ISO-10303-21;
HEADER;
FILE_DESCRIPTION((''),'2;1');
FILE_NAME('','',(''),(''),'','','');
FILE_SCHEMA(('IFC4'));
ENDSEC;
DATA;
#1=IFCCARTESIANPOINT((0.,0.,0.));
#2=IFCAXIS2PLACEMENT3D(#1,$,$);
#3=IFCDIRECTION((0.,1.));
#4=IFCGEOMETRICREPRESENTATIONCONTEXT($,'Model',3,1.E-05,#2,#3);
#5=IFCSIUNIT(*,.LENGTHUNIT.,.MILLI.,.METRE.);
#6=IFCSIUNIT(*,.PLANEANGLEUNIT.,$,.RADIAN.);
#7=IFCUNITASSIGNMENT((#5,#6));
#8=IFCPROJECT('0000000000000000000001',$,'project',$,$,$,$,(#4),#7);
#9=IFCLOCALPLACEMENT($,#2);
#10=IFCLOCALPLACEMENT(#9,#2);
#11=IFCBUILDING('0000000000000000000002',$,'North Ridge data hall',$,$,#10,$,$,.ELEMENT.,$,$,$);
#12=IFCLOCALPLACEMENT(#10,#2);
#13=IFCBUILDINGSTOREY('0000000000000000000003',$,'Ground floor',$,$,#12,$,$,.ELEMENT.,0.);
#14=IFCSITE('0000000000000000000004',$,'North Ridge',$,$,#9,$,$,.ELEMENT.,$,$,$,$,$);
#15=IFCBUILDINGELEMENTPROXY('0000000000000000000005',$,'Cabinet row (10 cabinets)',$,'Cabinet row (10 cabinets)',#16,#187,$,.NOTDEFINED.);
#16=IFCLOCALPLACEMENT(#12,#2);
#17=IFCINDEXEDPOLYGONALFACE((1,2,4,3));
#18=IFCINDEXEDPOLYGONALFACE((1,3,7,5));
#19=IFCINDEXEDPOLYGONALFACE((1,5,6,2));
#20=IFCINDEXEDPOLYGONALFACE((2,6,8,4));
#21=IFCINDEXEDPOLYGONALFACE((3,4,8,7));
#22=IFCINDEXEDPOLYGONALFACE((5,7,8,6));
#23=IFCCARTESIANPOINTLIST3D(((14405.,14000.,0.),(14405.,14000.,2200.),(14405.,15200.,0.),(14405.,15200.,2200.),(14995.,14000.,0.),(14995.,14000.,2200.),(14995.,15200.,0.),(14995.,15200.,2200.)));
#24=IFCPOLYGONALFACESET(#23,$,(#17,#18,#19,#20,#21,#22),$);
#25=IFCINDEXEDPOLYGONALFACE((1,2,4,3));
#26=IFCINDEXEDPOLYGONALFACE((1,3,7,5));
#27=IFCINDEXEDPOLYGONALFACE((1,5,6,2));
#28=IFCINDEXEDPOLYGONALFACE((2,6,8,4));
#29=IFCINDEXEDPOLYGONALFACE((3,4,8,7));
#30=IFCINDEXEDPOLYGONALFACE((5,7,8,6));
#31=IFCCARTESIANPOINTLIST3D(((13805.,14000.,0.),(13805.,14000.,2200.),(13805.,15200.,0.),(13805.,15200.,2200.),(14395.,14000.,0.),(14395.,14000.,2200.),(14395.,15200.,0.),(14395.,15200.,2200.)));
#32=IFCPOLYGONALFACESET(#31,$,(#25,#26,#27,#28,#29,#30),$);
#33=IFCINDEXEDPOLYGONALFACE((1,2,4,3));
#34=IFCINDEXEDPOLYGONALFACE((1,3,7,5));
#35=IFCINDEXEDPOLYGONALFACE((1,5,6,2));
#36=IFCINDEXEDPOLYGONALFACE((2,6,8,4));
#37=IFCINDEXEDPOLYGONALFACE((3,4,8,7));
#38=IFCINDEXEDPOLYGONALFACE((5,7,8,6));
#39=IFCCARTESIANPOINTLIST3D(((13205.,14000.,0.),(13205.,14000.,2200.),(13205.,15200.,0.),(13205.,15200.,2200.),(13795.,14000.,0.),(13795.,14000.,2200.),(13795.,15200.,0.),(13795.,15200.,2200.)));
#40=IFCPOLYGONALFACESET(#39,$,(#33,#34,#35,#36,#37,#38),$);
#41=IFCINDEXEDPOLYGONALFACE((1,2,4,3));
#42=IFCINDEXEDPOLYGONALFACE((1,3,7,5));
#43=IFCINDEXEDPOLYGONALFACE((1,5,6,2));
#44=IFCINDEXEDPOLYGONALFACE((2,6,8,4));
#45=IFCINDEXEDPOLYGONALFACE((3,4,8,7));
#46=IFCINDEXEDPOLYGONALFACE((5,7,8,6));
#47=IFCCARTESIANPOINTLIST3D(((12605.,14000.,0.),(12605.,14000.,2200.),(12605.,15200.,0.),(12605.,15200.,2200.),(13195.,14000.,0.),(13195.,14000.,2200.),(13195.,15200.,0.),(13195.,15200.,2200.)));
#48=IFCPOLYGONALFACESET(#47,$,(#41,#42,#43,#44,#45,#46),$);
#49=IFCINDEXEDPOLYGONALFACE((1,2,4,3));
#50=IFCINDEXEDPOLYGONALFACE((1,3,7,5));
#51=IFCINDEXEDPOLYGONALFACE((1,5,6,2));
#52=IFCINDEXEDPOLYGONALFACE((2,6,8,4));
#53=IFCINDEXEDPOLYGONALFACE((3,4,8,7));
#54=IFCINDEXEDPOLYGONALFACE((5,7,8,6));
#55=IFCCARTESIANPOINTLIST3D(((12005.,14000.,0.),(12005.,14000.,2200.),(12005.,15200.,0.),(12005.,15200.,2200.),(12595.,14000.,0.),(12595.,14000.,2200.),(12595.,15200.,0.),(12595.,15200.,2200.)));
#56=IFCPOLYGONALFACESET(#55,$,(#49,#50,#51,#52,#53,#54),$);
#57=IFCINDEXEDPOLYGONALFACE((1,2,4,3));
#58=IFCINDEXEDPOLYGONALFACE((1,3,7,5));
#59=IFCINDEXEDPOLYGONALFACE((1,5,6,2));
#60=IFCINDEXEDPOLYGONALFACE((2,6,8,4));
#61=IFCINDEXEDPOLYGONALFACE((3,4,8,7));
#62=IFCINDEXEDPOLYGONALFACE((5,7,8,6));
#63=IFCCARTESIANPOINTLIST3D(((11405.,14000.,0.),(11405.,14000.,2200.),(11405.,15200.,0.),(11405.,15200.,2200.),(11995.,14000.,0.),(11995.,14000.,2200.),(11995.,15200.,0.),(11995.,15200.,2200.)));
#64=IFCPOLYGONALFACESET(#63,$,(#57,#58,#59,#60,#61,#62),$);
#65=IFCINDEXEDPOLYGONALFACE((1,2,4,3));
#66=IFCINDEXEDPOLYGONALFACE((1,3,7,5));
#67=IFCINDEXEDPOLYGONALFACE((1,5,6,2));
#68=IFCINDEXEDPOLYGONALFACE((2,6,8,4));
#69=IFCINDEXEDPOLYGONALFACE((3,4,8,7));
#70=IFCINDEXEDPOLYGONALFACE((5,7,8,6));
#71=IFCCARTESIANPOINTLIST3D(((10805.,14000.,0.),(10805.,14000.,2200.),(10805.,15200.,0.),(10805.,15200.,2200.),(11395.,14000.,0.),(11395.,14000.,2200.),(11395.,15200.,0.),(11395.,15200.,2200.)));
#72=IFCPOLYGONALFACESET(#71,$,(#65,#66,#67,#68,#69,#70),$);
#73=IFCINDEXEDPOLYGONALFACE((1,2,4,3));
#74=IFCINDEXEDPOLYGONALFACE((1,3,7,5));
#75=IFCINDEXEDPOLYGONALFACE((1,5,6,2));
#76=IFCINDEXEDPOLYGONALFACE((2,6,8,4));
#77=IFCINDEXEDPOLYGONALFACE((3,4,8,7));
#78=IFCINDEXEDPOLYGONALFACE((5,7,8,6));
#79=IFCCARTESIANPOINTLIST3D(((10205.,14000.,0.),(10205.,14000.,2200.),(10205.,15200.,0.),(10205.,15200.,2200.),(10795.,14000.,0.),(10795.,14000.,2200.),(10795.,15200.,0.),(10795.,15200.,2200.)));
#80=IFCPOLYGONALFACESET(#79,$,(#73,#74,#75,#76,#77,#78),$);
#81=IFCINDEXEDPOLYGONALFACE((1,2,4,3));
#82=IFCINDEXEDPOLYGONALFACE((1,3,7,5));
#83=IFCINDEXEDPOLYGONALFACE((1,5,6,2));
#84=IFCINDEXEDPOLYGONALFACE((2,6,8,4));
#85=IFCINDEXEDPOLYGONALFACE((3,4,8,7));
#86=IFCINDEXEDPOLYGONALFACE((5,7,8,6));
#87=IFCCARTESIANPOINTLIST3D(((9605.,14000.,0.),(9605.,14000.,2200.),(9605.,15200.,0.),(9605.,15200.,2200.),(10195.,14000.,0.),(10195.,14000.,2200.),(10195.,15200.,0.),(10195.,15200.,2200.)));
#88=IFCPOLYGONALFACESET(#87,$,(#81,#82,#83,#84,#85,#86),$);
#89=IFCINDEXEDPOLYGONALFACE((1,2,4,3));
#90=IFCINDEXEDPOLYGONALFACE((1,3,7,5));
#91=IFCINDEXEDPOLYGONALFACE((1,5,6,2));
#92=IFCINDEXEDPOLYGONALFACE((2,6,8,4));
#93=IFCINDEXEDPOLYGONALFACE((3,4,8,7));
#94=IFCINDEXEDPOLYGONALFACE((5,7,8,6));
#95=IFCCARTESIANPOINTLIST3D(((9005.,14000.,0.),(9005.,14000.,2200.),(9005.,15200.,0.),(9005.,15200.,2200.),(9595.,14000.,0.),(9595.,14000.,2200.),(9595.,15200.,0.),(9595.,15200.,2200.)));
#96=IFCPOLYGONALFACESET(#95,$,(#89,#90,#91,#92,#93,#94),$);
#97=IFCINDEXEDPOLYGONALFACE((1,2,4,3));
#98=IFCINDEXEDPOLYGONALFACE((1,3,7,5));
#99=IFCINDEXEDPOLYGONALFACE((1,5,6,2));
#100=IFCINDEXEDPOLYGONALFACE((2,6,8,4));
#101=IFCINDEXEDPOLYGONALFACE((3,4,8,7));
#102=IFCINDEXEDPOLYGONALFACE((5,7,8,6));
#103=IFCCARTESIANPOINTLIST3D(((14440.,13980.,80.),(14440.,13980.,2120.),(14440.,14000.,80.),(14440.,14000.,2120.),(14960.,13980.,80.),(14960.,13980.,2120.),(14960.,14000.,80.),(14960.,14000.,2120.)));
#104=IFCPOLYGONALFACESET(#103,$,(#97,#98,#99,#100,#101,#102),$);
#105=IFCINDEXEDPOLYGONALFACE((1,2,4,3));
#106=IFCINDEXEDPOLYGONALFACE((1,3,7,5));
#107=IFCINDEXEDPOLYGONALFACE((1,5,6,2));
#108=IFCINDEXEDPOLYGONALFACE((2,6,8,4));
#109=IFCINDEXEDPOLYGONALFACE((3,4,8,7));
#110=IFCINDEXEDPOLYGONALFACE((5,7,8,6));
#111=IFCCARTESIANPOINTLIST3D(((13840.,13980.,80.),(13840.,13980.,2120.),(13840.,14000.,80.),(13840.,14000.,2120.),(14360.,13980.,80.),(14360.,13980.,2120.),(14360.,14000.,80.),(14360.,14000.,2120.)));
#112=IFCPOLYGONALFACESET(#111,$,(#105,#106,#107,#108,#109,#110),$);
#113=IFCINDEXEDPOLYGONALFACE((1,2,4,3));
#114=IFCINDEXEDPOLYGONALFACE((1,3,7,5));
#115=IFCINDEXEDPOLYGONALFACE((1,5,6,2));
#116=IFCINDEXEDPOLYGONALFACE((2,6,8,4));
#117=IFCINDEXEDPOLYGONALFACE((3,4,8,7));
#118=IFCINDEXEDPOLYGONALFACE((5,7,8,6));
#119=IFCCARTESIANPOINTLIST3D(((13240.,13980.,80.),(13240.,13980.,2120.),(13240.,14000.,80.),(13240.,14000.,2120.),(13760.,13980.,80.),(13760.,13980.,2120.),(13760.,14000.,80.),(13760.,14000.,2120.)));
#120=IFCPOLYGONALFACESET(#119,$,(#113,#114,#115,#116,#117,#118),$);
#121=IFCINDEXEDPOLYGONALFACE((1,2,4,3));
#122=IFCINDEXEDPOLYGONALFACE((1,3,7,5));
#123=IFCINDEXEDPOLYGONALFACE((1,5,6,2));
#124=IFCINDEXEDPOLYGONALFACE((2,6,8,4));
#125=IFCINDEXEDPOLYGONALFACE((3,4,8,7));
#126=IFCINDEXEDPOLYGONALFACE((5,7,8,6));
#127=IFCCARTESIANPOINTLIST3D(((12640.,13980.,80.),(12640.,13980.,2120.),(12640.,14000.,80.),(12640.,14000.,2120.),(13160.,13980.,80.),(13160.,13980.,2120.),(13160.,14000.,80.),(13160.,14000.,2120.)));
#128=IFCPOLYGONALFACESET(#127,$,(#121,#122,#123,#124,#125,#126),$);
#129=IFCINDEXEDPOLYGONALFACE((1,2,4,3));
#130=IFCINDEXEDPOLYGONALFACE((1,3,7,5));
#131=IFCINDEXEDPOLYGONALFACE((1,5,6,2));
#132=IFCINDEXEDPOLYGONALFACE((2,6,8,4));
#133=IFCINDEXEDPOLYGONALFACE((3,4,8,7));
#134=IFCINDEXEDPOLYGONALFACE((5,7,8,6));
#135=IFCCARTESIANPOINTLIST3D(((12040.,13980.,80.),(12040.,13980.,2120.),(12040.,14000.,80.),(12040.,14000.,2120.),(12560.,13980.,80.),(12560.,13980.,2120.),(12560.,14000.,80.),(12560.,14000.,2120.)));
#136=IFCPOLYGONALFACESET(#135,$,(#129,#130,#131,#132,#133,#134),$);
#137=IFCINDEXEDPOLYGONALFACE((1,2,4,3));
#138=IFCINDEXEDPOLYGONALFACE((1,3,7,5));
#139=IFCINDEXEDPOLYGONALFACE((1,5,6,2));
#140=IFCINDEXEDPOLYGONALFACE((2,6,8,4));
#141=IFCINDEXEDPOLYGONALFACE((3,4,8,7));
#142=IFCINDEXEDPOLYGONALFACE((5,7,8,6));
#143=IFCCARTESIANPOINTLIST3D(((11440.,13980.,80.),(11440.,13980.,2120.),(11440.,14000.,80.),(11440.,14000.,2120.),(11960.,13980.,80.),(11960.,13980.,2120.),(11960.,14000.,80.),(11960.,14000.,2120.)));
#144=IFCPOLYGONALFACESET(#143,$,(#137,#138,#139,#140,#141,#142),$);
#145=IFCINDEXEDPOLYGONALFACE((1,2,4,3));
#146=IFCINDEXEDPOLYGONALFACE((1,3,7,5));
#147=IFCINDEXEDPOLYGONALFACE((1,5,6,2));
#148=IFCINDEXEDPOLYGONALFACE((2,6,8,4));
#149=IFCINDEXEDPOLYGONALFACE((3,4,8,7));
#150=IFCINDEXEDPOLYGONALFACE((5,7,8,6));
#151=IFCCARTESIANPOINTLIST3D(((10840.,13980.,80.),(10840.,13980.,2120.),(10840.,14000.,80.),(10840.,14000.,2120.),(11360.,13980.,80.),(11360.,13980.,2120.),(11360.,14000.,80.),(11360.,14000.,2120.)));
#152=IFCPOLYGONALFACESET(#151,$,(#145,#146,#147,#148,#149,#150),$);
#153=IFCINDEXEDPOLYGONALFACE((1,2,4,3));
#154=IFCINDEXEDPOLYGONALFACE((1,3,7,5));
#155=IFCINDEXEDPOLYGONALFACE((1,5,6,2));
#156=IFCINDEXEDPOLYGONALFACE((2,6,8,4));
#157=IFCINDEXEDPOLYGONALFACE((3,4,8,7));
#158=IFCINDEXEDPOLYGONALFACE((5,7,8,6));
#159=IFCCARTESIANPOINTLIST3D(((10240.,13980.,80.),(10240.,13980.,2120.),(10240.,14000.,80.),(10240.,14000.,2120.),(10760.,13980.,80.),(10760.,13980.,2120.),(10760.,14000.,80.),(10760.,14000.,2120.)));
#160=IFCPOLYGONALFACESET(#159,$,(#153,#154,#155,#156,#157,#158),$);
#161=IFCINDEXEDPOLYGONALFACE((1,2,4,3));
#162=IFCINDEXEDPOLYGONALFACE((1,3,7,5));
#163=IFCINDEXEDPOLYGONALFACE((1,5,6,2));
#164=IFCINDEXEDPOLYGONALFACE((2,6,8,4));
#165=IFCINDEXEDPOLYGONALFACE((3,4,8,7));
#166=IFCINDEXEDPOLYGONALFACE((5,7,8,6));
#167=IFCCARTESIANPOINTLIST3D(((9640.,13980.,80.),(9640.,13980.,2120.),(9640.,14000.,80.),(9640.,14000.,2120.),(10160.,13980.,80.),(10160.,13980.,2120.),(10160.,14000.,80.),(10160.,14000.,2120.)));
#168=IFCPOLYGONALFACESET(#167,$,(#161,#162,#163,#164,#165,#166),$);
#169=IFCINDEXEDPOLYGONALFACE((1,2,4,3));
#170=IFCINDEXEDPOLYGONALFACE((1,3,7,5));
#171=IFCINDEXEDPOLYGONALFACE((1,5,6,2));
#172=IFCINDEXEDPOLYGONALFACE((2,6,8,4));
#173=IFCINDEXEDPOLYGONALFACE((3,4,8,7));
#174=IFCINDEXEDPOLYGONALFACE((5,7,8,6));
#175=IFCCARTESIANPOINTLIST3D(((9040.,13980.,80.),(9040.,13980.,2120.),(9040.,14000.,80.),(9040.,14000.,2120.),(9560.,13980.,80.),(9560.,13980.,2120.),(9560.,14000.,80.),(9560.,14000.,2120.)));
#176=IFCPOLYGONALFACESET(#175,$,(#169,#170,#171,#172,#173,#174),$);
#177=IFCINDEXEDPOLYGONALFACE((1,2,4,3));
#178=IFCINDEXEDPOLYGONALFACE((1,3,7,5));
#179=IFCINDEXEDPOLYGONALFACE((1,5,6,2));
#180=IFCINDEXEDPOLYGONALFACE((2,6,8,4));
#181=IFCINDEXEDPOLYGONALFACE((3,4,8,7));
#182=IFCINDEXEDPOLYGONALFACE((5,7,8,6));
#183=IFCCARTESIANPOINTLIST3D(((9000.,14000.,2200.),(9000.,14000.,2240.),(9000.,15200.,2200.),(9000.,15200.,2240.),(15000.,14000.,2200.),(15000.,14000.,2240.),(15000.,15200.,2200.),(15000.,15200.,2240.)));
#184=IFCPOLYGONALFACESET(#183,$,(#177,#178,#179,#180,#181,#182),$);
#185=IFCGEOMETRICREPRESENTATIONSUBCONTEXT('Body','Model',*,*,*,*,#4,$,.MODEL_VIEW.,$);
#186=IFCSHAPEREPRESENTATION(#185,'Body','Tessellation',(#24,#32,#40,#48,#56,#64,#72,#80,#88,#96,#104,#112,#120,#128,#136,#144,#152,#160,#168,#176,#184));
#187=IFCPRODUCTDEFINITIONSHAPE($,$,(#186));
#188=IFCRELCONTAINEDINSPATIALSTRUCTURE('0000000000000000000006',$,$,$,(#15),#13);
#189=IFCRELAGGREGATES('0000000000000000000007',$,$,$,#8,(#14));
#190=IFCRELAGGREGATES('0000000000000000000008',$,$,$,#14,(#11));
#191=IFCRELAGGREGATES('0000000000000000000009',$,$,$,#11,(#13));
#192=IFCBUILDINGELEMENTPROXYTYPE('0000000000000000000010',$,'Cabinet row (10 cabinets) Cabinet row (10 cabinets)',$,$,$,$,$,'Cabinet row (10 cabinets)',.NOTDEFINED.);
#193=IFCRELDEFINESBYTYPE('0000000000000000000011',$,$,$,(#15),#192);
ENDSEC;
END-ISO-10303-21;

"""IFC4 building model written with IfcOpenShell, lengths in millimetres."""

from ifc_helpers import new_model, si_unit, direction, frame, origin, place, context, subcontext, project, spatial, polyline, outline, extrude, source, transform, mapped, type_object, type_shapes, element, save


model = new_model("IFC4")

# Units and contexts
model_context = context("Model", 3, precision=1e-05, world=origin(), true_north=direction((0.0, 1.0)))
body_context = subcontext(model_context, "Body", "Model", "MODEL_VIEW")
ifc_project = project(units=[si_unit("LENGTHUNIT", "METRE", prefix="MILLI"), si_unit("PLANEANGLEUNIT", "RADIAN")], contexts=[model_context])

# Site, building, storey
site_placement = place(None, origin())
site = spatial("IfcSite", under=ifc_project, at=site_placement, Name="North Ridge", CompositionType="ELEMENT")
building_placement = place(site_placement, origin())
building = spatial("IfcBuilding", under=site, at=building_placement, Name="North Ridge data hall", CompositionType="ELEMENT")
storey_placement = place(building_placement, origin())
storey = spatial("IfcBuildingStorey", under=building, at=storey_placement, Name="Ground floor", CompositionType="ELEMENT", Elevation=0.0)

# Building element proxy
building_element_proxy_type_1 = type_object("IfcBuildingElementProxyType", Name="Cabinet row (10 cabinets) Cabinet row (10 cabinets)", ElementType="Cabinet row (10 cabinets)", PredefinedType="NOTDEFINED")
shared_shape_1 = source(origin(), body_context, "Body", "SweptSolid", [
    extrude(outline(polyline([(5.0, 0.0), (595.0, 0.0), (595.0, 1200.0), (5.0, 1200.0), (5.0, 0.0)])), origin(), (0.0, 0.0, 1.0), 2200.0),
    extrude(outline(polyline([(605.0, 0.0), (1195.0, 0.0), (1195.0, 1200.0), (605.0, 1200.0), (605.0, 0.0)])), origin(), (0.0, 0.0, 1.0), 2200.0),
    extrude(outline(polyline([(1205.0, 0.0), (1795.0, 0.0), (1795.0, 1200.0), (1205.0, 1200.0), (1205.0, 0.0)])), origin(), (0.0, 0.0, 1.0), 2200.0),
    extrude(outline(polyline([(1805.0, 0.0), (2395.0, 0.0), (2395.0, 1200.0), (1805.0, 1200.0), (1805.0, 0.0)])), origin(), (0.0, 0.0, 1.0), 2200.0),
    extrude(outline(polyline([(2405.0, 0.0), (2995.0, 0.0), (2995.0, 1200.0), (2405.0, 1200.0), (2405.0, 0.0)])), origin(), (0.0, 0.0, 1.0), 2200.0),
    extrude(outline(polyline([(3005.0, 0.0), (3595.0, 0.0), (3595.0, 1200.0), (3005.0, 1200.0), (3005.0, 0.0)])), origin(), (0.0, 0.0, 1.0), 2200.0),
    extrude(outline(polyline([(3605.0, 0.0), (4195.0, 0.0), (4195.0, 1200.0), (3605.0, 1200.0), (3605.0, 0.0)])), origin(), (0.0, 0.0, 1.0), 2200.0),
    extrude(outline(polyline([(4205.0, 0.0), (4795.0, 0.0), (4795.0, 1200.0), (4205.0, 1200.0), (4205.0, 0.0)])), origin(), (0.0, 0.0, 1.0), 2200.0),
    extrude(outline(polyline([(4805.0, 0.0), (5395.0, 0.0), (5395.0, 1200.0), (4805.0, 1200.0), (4805.0, 0.0)])), origin(), (0.0, 0.0, 1.0), 2200.0),
    extrude(outline(polyline([(5405.0, 0.0), (5995.0, 0.0), (5995.0, 1200.0), (5405.0, 1200.0), (5405.0, 0.0)])), origin(), (0.0, 0.0, 1.0), 2200.0),
    extrude(outline(polyline([(40.0, 1200.0), (560.0, 1200.0), (560.0, 1220.0), (40.0, 1220.0), (40.0, 1200.0)])), frame((0.0, 0.0, 80.0)), (0.0, 0.0, 1.0), 2040.0),
    extrude(outline(polyline([(640.0, 1200.0), (1160.0, 1200.0), (1160.0, 1220.0), (640.0, 1220.0), (640.0, 1200.0)])), frame((0.0, 0.0, 80.0)), (0.0, 0.0, 1.0), 2040.0),
    extrude(outline(polyline([(1240.0, 1200.0), (1760.0, 1200.0), (1760.0, 1220.0), (1240.0, 1220.0), (1240.0, 1200.0)])), frame((0.0, 0.0, 80.0)), (0.0, 0.0, 1.0), 2040.0),
    extrude(outline(polyline([(1840.0, 1200.0), (2360.0, 1200.0), (2360.0, 1220.0), (1840.0, 1220.0), (1840.0, 1200.0)])), frame((0.0, 0.0, 80.0)), (0.0, 0.0, 1.0), 2040.0),
    extrude(outline(polyline([(2440.0, 1200.0), (2960.0, 1200.0), (2960.0, 1220.0), (2440.0, 1220.0), (2440.0, 1200.0)])), frame((0.0, 0.0, 80.0)), (0.0, 0.0, 1.0), 2040.0),
    extrude(outline(polyline([(3040.0, 1200.0), (3560.0, 1200.0), (3560.0, 1220.0), (3040.0, 1220.0), (3040.0, 1200.0)])), frame((0.0, 0.0, 80.0)), (0.0, 0.0, 1.0), 2040.0),
    extrude(outline(polyline([(3640.0, 1200.0), (4160.0, 1200.0), (4160.0, 1220.0), (3640.0, 1220.0), (3640.0, 1200.0)])), frame((0.0, 0.0, 80.0)), (0.0, 0.0, 1.0), 2040.0),
    extrude(outline(polyline([(4240.0, 1200.0), (4760.0, 1200.0), (4760.0, 1220.0), (4240.0, 1220.0), (4240.0, 1200.0)])), frame((0.0, 0.0, 80.0)), (0.0, 0.0, 1.0), 2040.0),
    extrude(outline(polyline([(4840.0, 1200.0), (5360.0, 1200.0), (5360.0, 1220.0), (4840.0, 1220.0), (4840.0, 1200.0)])), frame((0.0, 0.0, 80.0)), (0.0, 0.0, 1.0), 2040.0),
    extrude(outline(polyline([(5440.0, 1200.0), (5960.0, 1200.0), (5960.0, 1220.0), (5440.0, 1220.0), (5440.0, 1200.0)])), frame((0.0, 0.0, 80.0)), (0.0, 0.0, 1.0), 2040.0),
    extrude(outline(polyline([(0.0, 0.0), (6000.0, 0.0), (6000.0, 1200.0), (0.0, 1200.0), (0.0, 0.0)])), frame((0.0, 0.0, 2200.0)), (0.0, 0.0, 1.0), 40.0),
])
type_shapes(building_element_proxy_type_1, [shared_shape_1])
for number, where, z_axis, x_axis, name in (
    (1, (15000.0, 15200.0, 0.0), (0.0, 0.0, 1.0), (-1.0, 0.0, 0.0), "Cabinet row (10 cabinets)"),
):
    element("IfcBuildingElementProxy", number, at=place(storey_placement, frame(where, z_axis=z_axis, x_axis=x_axis)), inside=storey, type_object=building_element_proxy_type_1, Name=name, ObjectType="Cabinet row (10 cabinets)", PredefinedType="NOTDEFINED", context=body_context, shape_type="MappedRepresentation", body=[
        mapped(shared_shape_1, transform((0.0, 0.0, 0.0))),
    ])

save(model, "model.ifc")
